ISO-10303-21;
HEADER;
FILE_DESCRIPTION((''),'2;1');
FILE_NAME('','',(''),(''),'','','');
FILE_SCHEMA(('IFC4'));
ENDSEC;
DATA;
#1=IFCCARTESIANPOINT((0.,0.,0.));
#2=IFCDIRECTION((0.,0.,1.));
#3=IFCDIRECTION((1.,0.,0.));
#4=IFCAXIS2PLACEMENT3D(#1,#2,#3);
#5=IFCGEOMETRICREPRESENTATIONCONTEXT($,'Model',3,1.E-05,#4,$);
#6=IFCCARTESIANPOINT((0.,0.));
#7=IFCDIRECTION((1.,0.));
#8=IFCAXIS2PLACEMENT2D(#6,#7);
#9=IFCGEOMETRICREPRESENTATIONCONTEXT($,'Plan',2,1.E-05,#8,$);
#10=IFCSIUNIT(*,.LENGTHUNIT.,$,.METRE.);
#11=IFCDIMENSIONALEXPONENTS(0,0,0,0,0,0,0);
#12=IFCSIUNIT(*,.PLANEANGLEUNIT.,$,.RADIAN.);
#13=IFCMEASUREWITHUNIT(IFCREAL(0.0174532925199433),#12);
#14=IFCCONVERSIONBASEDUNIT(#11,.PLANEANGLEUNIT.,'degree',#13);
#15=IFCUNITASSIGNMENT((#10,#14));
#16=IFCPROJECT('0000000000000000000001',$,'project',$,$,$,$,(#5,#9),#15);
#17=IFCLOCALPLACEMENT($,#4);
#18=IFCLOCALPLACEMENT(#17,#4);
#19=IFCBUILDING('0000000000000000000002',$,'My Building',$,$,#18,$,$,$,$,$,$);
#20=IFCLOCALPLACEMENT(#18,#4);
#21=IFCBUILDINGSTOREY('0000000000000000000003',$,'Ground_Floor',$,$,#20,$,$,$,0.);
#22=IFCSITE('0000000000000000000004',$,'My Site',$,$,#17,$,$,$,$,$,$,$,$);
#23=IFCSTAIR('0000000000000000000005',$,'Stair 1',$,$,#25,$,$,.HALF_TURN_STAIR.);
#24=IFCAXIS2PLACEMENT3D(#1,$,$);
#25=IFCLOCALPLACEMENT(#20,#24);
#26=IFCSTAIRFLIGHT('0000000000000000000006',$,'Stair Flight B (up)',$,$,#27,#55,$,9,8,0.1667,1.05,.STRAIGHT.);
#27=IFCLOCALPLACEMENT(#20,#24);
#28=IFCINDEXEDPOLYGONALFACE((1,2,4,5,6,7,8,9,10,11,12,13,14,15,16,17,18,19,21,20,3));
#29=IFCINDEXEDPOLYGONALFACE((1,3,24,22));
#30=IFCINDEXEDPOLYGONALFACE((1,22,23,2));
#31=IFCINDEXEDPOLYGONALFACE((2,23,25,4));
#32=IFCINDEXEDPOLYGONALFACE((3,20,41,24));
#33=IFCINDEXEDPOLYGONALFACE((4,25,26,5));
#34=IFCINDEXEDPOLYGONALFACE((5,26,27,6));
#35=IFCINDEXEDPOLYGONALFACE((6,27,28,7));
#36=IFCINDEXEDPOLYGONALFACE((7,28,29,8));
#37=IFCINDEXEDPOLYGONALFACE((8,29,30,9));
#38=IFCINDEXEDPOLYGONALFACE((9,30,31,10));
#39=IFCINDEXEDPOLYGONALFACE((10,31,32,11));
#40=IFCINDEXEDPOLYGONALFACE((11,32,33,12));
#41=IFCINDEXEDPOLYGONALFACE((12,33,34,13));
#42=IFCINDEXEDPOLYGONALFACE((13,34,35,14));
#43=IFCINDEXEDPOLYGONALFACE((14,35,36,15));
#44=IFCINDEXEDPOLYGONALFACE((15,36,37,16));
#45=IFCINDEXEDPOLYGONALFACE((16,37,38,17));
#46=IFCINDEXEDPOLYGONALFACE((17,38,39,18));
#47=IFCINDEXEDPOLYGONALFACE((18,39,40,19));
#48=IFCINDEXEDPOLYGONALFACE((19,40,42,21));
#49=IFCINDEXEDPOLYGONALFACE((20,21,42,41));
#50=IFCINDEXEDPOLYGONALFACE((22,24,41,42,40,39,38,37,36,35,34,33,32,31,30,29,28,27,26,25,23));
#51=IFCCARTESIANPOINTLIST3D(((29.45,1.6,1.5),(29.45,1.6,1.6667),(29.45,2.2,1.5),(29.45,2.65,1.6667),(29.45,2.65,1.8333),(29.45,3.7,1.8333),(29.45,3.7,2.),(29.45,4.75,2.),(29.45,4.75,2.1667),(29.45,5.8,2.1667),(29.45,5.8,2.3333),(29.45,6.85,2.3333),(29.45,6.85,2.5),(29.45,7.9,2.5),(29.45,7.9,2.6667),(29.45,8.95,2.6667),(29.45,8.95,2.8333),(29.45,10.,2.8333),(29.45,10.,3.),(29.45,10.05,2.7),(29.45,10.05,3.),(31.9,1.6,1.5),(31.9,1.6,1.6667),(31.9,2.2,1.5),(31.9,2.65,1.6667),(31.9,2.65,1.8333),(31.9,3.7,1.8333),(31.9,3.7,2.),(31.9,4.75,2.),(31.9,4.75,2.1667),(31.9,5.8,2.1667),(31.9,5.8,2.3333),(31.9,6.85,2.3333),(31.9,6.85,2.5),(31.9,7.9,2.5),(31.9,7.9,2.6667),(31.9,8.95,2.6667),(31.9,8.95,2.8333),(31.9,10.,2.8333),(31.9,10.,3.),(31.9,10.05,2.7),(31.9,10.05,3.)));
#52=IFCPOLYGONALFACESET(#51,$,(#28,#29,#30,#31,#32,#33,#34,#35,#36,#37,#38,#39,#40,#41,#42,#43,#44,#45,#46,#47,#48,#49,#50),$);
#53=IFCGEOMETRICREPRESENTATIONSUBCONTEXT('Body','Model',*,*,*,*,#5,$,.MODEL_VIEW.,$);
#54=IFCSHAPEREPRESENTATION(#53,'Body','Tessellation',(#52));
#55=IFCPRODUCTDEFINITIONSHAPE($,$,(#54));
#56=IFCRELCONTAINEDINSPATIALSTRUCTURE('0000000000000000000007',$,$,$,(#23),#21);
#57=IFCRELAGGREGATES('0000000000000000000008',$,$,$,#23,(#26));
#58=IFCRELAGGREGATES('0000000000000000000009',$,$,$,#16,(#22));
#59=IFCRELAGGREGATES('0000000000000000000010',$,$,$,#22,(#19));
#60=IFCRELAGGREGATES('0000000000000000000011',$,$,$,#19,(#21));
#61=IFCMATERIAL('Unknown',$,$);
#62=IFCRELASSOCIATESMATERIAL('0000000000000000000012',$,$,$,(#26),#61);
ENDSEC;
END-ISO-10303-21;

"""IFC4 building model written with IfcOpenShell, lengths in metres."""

from ifc_helpers import new_model, entity, si_unit, converted_unit, frame, origin_with_axes, origin_2d_with_axis, place, context, subcontext, project, spatial, polyline, outline, extrude, material, element, aggregate, save


model = new_model("IFC4")

# Units and contexts
model_context = context("Model", 3, precision=1e-05, world=origin_with_axes())
plan_context = context("Plan", 2, precision=1e-05, world=origin_2d_with_axis())
body_context = subcontext(model_context, "Body", "Model", "MODEL_VIEW")
ifc_project = project(units=[si_unit("LENGTHUNIT", "METRE"), converted_unit("PLANEANGLEUNIT", "degree", entity("IfcReal", 0.0174532925199433), si_unit("PLANEANGLEUNIT", "RADIAN"), dimensions=[0, 0, 0, 0, 0, 0, 0])], contexts=[model_context, plan_context])

# Site, building, storey
site_placement = place(None, origin_with_axes())
site = spatial("IfcSite", under=ifc_project, at=site_placement, Name="My Site")
building_placement = place(site_placement, origin_with_axes())
building = spatial("IfcBuilding", under=site, at=building_placement, Name="My Building")
storey_placement = place(building_placement, origin_with_axes())
storey = spatial("IfcBuildingStorey", under=building, at=storey_placement, Name="Ground_Floor", Elevation=0.0)

# Shared definitions
ifc_material = material(Name="Unknown")

# Stair
stair_placement = place(storey_placement, origin_with_axes())
stair = element("IfcStair", 1, at=stair_placement, inside=storey, Name="Stair 1", PredefinedType="HALF_TURN_STAIR")

# Stair flight
stair_flight_1_placement = place(stair_placement, origin_with_axes())
stair_flight_1 = element("IfcStairFlight", 2, at=stair_flight_1_placement, material=ifc_material, Name="Stair Flight B (up)", NumberOfRisers=9, NumberOfTreads=8, PredefinedType="STRAIGHT", RiserHeight=0.1667, TreadLength=1.05, context=body_context, shape_type="SweptSolid", body=[
    extrude(outline(polyline([(1.6, 1.5), (1.6, 1.6667), (2.65, 1.6667), (2.65, 1.8333), (3.7, 1.8333), (3.7, 1.8333), (3.7, 2.0), (4.75, 2.0), (4.75, 2.1667), (5.8, 2.1667), (5.8, 2.3333), (6.85, 2.3333), (6.85, 2.5), (7.9, 2.5), (7.9, 2.5), (7.9, 2.6667), (8.95, 2.6667), (8.95, 2.6667), (8.95, 2.8333), (10.0, 2.8333), (10.0, 3.0), (10.05, 3.0), (10.05, 2.7), (2.2, 1.5), (1.6, 1.5)])), frame((29.45, 0.0, 0.0), z_axis=(1.0, 0.0, 0.0), x_axis=(0.0, 1.0, 0.0)), (0.0, 0.0, 1.0), 2.45),
])
aggregate(stair, [stair_flight_1])

save(model, "model.ifc")
